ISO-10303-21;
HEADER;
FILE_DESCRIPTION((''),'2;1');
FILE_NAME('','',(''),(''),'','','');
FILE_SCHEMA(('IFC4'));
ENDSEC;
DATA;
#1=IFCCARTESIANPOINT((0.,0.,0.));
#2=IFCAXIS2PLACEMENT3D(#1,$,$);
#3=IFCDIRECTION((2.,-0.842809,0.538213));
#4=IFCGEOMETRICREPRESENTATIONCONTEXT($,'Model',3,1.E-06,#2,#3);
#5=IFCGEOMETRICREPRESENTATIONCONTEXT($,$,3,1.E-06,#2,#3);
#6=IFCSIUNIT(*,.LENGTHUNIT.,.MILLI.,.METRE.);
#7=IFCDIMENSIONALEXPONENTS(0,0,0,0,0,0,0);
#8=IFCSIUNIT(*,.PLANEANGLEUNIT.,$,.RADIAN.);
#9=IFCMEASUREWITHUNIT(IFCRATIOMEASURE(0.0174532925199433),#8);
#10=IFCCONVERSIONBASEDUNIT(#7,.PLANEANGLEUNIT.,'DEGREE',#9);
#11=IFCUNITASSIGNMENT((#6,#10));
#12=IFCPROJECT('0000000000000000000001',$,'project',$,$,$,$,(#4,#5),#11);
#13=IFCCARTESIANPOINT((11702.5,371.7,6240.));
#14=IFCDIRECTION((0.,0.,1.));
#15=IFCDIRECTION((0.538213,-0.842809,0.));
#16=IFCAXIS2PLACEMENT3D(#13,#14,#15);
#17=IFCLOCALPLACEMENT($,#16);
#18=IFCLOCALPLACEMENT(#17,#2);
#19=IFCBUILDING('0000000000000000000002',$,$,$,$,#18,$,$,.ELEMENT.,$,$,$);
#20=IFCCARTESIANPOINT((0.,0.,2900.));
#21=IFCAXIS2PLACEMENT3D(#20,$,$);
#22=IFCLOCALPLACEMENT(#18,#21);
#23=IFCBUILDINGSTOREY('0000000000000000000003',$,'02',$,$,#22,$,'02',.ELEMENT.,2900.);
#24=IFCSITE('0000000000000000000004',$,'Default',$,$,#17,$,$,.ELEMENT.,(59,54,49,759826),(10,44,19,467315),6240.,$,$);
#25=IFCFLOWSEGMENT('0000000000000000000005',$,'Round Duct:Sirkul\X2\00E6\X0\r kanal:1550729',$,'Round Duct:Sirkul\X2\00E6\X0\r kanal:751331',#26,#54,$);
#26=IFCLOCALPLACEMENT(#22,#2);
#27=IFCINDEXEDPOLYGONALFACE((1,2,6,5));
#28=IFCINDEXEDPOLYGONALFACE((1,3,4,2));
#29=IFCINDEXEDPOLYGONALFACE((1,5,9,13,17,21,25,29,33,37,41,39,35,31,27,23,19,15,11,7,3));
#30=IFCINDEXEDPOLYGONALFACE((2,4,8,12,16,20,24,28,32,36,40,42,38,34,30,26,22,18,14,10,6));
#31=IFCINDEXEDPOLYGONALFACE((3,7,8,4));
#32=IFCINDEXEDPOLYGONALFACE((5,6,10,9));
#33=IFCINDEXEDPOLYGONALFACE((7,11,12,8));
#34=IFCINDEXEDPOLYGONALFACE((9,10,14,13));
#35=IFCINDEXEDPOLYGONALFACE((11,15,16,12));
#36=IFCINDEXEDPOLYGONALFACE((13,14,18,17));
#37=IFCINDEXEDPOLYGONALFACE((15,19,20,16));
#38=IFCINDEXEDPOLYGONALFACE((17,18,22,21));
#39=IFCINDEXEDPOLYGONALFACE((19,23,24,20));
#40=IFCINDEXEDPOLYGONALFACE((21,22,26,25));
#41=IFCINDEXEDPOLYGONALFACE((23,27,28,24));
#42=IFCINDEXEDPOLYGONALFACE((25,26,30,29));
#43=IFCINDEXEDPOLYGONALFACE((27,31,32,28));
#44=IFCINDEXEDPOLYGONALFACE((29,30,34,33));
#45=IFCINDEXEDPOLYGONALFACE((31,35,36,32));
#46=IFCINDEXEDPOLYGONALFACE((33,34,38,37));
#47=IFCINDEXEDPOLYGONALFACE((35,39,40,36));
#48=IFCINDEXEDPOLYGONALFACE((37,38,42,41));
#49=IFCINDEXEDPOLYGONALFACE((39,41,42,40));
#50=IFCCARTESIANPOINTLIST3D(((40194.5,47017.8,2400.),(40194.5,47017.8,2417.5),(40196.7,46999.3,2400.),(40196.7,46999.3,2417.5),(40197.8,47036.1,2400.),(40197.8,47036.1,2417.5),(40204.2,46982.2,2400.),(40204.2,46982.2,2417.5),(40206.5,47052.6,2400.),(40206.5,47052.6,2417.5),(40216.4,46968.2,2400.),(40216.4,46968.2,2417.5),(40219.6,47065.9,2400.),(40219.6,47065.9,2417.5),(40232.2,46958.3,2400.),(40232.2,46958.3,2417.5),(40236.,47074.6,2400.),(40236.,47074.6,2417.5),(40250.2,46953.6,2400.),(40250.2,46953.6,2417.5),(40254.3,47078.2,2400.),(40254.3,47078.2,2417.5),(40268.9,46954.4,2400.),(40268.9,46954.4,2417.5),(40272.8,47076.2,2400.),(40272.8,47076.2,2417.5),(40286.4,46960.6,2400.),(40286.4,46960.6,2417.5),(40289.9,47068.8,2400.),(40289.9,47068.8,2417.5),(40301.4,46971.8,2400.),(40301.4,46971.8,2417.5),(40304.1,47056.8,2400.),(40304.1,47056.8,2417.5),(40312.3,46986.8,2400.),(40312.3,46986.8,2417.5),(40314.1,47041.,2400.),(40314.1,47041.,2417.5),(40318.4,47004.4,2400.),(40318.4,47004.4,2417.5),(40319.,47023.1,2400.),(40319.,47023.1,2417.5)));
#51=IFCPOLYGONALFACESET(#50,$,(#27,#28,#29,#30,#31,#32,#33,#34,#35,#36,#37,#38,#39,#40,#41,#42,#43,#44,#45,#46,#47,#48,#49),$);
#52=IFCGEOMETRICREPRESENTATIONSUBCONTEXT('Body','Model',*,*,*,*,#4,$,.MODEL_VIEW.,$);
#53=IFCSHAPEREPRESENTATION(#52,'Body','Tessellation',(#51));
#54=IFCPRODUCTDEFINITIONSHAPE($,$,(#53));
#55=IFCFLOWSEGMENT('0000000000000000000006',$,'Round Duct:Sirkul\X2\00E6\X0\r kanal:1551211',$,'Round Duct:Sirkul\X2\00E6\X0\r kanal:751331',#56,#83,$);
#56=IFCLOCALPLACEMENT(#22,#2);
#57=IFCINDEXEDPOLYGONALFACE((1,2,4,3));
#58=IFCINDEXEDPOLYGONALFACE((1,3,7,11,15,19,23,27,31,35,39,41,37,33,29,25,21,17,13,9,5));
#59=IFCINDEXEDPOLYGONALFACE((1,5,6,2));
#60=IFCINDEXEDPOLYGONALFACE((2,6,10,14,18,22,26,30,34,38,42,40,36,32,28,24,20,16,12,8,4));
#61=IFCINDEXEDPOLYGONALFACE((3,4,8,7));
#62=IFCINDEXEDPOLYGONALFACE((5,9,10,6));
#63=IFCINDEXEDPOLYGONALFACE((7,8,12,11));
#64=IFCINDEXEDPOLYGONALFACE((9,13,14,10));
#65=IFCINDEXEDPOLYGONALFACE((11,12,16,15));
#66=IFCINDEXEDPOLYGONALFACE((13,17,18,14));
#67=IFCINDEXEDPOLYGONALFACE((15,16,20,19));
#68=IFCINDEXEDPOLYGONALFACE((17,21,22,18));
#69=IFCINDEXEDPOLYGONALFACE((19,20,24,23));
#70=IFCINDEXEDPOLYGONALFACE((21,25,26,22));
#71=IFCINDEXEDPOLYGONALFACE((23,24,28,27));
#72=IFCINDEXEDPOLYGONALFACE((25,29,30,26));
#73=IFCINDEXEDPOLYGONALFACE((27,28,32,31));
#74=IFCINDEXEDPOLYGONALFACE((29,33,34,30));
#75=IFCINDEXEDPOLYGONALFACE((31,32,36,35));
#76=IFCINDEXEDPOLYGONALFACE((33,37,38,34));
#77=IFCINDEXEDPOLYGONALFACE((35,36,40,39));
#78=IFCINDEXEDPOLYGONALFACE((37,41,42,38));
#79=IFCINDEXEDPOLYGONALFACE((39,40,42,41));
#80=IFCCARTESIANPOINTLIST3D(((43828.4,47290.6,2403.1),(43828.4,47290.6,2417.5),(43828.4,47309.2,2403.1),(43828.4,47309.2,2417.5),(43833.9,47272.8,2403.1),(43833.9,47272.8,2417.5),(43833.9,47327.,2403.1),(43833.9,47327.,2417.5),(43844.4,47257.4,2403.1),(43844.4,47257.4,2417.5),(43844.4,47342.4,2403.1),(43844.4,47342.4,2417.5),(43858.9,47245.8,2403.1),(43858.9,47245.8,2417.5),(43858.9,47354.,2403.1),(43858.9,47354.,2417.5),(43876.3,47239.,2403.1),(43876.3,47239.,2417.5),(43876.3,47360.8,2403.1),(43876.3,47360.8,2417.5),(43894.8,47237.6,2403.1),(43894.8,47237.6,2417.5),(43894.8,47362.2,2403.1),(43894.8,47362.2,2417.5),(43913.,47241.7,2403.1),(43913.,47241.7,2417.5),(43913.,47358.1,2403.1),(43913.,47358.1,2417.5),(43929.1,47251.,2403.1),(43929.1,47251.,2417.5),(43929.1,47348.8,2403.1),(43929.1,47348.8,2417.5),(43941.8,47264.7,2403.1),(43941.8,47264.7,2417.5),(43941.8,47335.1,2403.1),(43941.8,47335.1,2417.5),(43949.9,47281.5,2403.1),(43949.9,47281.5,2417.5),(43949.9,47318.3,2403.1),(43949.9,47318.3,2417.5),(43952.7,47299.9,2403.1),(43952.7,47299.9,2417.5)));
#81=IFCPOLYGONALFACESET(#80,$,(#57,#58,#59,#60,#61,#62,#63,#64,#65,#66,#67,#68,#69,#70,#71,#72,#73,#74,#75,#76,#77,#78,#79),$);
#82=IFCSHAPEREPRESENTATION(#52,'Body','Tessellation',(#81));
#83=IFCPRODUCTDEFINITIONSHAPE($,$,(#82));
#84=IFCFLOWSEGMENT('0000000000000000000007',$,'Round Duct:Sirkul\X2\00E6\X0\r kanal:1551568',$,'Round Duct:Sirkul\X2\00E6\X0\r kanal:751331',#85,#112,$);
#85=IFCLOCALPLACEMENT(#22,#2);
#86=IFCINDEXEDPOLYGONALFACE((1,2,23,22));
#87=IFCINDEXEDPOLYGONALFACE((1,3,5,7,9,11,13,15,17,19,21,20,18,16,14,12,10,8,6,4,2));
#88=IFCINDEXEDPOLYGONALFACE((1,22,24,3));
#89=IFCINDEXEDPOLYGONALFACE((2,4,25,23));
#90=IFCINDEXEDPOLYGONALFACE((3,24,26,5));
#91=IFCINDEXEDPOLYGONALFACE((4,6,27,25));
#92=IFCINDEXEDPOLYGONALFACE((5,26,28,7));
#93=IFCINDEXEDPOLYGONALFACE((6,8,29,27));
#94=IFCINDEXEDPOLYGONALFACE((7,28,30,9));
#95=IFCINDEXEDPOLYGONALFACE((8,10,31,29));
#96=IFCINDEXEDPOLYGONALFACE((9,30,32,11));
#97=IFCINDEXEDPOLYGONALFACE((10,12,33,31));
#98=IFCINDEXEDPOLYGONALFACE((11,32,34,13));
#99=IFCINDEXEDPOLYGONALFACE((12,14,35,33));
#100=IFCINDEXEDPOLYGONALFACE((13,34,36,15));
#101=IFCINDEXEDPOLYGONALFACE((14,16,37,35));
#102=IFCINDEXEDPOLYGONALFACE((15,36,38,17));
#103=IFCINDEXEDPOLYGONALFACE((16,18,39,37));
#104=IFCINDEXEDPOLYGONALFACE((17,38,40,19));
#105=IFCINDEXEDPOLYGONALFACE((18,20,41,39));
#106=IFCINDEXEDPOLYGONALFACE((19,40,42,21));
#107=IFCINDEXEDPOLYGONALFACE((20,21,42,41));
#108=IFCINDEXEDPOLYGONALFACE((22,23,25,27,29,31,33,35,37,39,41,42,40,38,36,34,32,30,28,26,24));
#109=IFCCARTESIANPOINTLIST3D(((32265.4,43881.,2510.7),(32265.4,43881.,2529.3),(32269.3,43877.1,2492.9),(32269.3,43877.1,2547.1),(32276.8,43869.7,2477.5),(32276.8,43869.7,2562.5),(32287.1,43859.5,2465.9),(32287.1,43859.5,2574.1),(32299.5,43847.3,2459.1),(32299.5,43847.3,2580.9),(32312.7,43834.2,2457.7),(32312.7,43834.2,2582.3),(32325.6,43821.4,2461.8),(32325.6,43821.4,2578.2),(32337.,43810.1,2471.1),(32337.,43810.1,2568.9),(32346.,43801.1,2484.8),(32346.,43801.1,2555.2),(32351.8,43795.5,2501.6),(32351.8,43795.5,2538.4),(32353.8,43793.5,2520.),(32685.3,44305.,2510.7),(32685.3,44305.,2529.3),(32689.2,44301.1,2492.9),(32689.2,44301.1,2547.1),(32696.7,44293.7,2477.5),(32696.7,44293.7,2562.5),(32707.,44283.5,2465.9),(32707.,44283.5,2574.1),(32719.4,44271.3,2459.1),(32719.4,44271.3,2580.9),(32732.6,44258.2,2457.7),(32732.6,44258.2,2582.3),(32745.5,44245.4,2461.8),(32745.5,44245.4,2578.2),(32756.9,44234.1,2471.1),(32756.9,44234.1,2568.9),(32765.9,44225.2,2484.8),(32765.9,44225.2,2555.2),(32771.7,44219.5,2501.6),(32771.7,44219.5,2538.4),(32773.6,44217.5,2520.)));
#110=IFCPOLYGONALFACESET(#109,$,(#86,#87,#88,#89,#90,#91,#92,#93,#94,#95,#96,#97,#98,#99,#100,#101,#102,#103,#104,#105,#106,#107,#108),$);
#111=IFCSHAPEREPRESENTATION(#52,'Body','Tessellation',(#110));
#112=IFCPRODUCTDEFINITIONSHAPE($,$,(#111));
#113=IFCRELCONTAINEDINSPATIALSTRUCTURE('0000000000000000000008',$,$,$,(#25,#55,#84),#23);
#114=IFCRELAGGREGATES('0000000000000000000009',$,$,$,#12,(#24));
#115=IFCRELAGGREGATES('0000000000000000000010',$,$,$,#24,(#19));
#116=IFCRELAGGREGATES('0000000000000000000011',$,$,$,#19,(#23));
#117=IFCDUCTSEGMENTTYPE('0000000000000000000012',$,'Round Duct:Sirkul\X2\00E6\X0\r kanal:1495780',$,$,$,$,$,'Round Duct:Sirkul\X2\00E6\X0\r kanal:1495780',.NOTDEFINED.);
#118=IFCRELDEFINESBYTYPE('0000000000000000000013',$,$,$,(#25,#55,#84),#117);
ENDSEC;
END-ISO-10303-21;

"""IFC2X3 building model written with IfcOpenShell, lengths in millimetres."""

from ifc_helpers import new_model, entity, si_unit, converted_unit, direction, frame, frame_2d, origin, place, context, subcontext, project, spatial, circle, extrude, type_object, element, save


model = new_model("IFC2X3")

# Units and contexts
model_context = context("Model", 3, precision=1e-06, world=origin(), true_north=direction((2.0, -0.842809, 0.538213)))
context_of_model = context(None, 3, precision=1e-06, world=origin(), true_north=direction((2.0, -0.842809, 0.538213)))
body_context = subcontext(model_context, "Body", "Model", "MODEL_VIEW")
ifc_project = project(units=[si_unit("LENGTHUNIT", "METRE", prefix="MILLI"), converted_unit("PLANEANGLEUNIT", "DEGREE", entity("IfcRatioMeasure", 0.0174532925199433), si_unit("PLANEANGLEUNIT", "RADIAN"), dimensions=[0, 0, 0, 0, 0, 0, 0])], contexts=[model_context, context_of_model])

# Site, building, storey
site_placement = place(None, frame((11702.5, 371.7, 6240.0), z_axis=(0.0, 0.0, 1.0), x_axis=(0.538213, -0.842809, 0.0)))
site = spatial("IfcSite", under=ifc_project, at=site_placement, Name="Default", CompositionType="ELEMENT", RefLatitude=(59, 54, 49, 759826), RefLongitude=(10, 44, 19, 467315), RefElevation=6240.0)
building_placement = place(site_placement, origin())
building = spatial("IfcBuilding", under=site, at=building_placement, CompositionType="ELEMENT")
storey_placement = place(building_placement, frame((0.0, 0.0, 2900.0)))
storey = spatial("IfcBuildingStorey", under=building, at=storey_placement, Name="02", LongName="02", CompositionType="ELEMENT", Elevation=2900.0)

# Flow segments
duct_segment_type_1 = type_object("IfcDuctSegmentType", Name="Round Duct:Sirkulær kanal:1495780", ElementType="Round Duct:Sirkulær kanal:1495780", PredefinedType="NOTDEFINED")
flow_segment_1_placement = place(storey_placement, origin())
element("IfcFlowSegment", 1, at=flow_segment_1_placement, inside=storey, type_object=duct_segment_type_1, Name="Round Duct:Sirkulær kanal:1550729", ObjectType="Round Duct:Sirkulær kanal:751331", context=body_context, shape_type="SweptSolid", body=[
    extrude(circle(Radius=62.5, at=frame_2d((0.0, 0.0), x_axis=(1.0, 0.0))), frame((40256.9, 47015.8, 2400.0), z_axis=(0.0, 0.0, 1.0), x_axis=(0.710554, -0.703643, 0.0)), (0.0, 0.0, 1.0), 17.5),
])
flow_segment_2_placement = place(storey_placement, origin())
element("IfcFlowSegment", 2, at=flow_segment_2_placement, inside=storey, type_object=duct_segment_type_1, Name="Round Duct:Sirkulær kanal:1551211", ObjectType="Round Duct:Sirkulær kanal:751331", context=body_context, shape_type="SweptSolid", body=[
    extrude(circle(Radius=62.5, at=frame_2d((0.0, 0.0), x_axis=(1.0, 0.0))), frame((43890.2, 47299.9, 2403.1)), (0.0, 0.0, 1.0), 14.4),
])
flow_segment_3_placement = place(storey_placement, origin())
element("IfcFlowSegment", 3, at=flow_segment_3_placement, inside=storey, type_object=duct_segment_type_1, Name="Round Duct:Sirkulær kanal:1551568", ObjectType="Round Duct:Sirkulær kanal:751331", context=body_context, shape_type="SweptSolid", body=[
    extrude(circle(Radius=62.5, at=frame_2d((0.0, 0.0), x_axis=(1.0, 0.0))), frame((32309.4, 43837.5, 2520.0), z_axis=(0.703643, 0.710554, 0.0), x_axis=(0.710554, -0.703643, 0.0)), (0.0, 0.0, 1.0), 596.7),
])

save(model, "model.ifc")
